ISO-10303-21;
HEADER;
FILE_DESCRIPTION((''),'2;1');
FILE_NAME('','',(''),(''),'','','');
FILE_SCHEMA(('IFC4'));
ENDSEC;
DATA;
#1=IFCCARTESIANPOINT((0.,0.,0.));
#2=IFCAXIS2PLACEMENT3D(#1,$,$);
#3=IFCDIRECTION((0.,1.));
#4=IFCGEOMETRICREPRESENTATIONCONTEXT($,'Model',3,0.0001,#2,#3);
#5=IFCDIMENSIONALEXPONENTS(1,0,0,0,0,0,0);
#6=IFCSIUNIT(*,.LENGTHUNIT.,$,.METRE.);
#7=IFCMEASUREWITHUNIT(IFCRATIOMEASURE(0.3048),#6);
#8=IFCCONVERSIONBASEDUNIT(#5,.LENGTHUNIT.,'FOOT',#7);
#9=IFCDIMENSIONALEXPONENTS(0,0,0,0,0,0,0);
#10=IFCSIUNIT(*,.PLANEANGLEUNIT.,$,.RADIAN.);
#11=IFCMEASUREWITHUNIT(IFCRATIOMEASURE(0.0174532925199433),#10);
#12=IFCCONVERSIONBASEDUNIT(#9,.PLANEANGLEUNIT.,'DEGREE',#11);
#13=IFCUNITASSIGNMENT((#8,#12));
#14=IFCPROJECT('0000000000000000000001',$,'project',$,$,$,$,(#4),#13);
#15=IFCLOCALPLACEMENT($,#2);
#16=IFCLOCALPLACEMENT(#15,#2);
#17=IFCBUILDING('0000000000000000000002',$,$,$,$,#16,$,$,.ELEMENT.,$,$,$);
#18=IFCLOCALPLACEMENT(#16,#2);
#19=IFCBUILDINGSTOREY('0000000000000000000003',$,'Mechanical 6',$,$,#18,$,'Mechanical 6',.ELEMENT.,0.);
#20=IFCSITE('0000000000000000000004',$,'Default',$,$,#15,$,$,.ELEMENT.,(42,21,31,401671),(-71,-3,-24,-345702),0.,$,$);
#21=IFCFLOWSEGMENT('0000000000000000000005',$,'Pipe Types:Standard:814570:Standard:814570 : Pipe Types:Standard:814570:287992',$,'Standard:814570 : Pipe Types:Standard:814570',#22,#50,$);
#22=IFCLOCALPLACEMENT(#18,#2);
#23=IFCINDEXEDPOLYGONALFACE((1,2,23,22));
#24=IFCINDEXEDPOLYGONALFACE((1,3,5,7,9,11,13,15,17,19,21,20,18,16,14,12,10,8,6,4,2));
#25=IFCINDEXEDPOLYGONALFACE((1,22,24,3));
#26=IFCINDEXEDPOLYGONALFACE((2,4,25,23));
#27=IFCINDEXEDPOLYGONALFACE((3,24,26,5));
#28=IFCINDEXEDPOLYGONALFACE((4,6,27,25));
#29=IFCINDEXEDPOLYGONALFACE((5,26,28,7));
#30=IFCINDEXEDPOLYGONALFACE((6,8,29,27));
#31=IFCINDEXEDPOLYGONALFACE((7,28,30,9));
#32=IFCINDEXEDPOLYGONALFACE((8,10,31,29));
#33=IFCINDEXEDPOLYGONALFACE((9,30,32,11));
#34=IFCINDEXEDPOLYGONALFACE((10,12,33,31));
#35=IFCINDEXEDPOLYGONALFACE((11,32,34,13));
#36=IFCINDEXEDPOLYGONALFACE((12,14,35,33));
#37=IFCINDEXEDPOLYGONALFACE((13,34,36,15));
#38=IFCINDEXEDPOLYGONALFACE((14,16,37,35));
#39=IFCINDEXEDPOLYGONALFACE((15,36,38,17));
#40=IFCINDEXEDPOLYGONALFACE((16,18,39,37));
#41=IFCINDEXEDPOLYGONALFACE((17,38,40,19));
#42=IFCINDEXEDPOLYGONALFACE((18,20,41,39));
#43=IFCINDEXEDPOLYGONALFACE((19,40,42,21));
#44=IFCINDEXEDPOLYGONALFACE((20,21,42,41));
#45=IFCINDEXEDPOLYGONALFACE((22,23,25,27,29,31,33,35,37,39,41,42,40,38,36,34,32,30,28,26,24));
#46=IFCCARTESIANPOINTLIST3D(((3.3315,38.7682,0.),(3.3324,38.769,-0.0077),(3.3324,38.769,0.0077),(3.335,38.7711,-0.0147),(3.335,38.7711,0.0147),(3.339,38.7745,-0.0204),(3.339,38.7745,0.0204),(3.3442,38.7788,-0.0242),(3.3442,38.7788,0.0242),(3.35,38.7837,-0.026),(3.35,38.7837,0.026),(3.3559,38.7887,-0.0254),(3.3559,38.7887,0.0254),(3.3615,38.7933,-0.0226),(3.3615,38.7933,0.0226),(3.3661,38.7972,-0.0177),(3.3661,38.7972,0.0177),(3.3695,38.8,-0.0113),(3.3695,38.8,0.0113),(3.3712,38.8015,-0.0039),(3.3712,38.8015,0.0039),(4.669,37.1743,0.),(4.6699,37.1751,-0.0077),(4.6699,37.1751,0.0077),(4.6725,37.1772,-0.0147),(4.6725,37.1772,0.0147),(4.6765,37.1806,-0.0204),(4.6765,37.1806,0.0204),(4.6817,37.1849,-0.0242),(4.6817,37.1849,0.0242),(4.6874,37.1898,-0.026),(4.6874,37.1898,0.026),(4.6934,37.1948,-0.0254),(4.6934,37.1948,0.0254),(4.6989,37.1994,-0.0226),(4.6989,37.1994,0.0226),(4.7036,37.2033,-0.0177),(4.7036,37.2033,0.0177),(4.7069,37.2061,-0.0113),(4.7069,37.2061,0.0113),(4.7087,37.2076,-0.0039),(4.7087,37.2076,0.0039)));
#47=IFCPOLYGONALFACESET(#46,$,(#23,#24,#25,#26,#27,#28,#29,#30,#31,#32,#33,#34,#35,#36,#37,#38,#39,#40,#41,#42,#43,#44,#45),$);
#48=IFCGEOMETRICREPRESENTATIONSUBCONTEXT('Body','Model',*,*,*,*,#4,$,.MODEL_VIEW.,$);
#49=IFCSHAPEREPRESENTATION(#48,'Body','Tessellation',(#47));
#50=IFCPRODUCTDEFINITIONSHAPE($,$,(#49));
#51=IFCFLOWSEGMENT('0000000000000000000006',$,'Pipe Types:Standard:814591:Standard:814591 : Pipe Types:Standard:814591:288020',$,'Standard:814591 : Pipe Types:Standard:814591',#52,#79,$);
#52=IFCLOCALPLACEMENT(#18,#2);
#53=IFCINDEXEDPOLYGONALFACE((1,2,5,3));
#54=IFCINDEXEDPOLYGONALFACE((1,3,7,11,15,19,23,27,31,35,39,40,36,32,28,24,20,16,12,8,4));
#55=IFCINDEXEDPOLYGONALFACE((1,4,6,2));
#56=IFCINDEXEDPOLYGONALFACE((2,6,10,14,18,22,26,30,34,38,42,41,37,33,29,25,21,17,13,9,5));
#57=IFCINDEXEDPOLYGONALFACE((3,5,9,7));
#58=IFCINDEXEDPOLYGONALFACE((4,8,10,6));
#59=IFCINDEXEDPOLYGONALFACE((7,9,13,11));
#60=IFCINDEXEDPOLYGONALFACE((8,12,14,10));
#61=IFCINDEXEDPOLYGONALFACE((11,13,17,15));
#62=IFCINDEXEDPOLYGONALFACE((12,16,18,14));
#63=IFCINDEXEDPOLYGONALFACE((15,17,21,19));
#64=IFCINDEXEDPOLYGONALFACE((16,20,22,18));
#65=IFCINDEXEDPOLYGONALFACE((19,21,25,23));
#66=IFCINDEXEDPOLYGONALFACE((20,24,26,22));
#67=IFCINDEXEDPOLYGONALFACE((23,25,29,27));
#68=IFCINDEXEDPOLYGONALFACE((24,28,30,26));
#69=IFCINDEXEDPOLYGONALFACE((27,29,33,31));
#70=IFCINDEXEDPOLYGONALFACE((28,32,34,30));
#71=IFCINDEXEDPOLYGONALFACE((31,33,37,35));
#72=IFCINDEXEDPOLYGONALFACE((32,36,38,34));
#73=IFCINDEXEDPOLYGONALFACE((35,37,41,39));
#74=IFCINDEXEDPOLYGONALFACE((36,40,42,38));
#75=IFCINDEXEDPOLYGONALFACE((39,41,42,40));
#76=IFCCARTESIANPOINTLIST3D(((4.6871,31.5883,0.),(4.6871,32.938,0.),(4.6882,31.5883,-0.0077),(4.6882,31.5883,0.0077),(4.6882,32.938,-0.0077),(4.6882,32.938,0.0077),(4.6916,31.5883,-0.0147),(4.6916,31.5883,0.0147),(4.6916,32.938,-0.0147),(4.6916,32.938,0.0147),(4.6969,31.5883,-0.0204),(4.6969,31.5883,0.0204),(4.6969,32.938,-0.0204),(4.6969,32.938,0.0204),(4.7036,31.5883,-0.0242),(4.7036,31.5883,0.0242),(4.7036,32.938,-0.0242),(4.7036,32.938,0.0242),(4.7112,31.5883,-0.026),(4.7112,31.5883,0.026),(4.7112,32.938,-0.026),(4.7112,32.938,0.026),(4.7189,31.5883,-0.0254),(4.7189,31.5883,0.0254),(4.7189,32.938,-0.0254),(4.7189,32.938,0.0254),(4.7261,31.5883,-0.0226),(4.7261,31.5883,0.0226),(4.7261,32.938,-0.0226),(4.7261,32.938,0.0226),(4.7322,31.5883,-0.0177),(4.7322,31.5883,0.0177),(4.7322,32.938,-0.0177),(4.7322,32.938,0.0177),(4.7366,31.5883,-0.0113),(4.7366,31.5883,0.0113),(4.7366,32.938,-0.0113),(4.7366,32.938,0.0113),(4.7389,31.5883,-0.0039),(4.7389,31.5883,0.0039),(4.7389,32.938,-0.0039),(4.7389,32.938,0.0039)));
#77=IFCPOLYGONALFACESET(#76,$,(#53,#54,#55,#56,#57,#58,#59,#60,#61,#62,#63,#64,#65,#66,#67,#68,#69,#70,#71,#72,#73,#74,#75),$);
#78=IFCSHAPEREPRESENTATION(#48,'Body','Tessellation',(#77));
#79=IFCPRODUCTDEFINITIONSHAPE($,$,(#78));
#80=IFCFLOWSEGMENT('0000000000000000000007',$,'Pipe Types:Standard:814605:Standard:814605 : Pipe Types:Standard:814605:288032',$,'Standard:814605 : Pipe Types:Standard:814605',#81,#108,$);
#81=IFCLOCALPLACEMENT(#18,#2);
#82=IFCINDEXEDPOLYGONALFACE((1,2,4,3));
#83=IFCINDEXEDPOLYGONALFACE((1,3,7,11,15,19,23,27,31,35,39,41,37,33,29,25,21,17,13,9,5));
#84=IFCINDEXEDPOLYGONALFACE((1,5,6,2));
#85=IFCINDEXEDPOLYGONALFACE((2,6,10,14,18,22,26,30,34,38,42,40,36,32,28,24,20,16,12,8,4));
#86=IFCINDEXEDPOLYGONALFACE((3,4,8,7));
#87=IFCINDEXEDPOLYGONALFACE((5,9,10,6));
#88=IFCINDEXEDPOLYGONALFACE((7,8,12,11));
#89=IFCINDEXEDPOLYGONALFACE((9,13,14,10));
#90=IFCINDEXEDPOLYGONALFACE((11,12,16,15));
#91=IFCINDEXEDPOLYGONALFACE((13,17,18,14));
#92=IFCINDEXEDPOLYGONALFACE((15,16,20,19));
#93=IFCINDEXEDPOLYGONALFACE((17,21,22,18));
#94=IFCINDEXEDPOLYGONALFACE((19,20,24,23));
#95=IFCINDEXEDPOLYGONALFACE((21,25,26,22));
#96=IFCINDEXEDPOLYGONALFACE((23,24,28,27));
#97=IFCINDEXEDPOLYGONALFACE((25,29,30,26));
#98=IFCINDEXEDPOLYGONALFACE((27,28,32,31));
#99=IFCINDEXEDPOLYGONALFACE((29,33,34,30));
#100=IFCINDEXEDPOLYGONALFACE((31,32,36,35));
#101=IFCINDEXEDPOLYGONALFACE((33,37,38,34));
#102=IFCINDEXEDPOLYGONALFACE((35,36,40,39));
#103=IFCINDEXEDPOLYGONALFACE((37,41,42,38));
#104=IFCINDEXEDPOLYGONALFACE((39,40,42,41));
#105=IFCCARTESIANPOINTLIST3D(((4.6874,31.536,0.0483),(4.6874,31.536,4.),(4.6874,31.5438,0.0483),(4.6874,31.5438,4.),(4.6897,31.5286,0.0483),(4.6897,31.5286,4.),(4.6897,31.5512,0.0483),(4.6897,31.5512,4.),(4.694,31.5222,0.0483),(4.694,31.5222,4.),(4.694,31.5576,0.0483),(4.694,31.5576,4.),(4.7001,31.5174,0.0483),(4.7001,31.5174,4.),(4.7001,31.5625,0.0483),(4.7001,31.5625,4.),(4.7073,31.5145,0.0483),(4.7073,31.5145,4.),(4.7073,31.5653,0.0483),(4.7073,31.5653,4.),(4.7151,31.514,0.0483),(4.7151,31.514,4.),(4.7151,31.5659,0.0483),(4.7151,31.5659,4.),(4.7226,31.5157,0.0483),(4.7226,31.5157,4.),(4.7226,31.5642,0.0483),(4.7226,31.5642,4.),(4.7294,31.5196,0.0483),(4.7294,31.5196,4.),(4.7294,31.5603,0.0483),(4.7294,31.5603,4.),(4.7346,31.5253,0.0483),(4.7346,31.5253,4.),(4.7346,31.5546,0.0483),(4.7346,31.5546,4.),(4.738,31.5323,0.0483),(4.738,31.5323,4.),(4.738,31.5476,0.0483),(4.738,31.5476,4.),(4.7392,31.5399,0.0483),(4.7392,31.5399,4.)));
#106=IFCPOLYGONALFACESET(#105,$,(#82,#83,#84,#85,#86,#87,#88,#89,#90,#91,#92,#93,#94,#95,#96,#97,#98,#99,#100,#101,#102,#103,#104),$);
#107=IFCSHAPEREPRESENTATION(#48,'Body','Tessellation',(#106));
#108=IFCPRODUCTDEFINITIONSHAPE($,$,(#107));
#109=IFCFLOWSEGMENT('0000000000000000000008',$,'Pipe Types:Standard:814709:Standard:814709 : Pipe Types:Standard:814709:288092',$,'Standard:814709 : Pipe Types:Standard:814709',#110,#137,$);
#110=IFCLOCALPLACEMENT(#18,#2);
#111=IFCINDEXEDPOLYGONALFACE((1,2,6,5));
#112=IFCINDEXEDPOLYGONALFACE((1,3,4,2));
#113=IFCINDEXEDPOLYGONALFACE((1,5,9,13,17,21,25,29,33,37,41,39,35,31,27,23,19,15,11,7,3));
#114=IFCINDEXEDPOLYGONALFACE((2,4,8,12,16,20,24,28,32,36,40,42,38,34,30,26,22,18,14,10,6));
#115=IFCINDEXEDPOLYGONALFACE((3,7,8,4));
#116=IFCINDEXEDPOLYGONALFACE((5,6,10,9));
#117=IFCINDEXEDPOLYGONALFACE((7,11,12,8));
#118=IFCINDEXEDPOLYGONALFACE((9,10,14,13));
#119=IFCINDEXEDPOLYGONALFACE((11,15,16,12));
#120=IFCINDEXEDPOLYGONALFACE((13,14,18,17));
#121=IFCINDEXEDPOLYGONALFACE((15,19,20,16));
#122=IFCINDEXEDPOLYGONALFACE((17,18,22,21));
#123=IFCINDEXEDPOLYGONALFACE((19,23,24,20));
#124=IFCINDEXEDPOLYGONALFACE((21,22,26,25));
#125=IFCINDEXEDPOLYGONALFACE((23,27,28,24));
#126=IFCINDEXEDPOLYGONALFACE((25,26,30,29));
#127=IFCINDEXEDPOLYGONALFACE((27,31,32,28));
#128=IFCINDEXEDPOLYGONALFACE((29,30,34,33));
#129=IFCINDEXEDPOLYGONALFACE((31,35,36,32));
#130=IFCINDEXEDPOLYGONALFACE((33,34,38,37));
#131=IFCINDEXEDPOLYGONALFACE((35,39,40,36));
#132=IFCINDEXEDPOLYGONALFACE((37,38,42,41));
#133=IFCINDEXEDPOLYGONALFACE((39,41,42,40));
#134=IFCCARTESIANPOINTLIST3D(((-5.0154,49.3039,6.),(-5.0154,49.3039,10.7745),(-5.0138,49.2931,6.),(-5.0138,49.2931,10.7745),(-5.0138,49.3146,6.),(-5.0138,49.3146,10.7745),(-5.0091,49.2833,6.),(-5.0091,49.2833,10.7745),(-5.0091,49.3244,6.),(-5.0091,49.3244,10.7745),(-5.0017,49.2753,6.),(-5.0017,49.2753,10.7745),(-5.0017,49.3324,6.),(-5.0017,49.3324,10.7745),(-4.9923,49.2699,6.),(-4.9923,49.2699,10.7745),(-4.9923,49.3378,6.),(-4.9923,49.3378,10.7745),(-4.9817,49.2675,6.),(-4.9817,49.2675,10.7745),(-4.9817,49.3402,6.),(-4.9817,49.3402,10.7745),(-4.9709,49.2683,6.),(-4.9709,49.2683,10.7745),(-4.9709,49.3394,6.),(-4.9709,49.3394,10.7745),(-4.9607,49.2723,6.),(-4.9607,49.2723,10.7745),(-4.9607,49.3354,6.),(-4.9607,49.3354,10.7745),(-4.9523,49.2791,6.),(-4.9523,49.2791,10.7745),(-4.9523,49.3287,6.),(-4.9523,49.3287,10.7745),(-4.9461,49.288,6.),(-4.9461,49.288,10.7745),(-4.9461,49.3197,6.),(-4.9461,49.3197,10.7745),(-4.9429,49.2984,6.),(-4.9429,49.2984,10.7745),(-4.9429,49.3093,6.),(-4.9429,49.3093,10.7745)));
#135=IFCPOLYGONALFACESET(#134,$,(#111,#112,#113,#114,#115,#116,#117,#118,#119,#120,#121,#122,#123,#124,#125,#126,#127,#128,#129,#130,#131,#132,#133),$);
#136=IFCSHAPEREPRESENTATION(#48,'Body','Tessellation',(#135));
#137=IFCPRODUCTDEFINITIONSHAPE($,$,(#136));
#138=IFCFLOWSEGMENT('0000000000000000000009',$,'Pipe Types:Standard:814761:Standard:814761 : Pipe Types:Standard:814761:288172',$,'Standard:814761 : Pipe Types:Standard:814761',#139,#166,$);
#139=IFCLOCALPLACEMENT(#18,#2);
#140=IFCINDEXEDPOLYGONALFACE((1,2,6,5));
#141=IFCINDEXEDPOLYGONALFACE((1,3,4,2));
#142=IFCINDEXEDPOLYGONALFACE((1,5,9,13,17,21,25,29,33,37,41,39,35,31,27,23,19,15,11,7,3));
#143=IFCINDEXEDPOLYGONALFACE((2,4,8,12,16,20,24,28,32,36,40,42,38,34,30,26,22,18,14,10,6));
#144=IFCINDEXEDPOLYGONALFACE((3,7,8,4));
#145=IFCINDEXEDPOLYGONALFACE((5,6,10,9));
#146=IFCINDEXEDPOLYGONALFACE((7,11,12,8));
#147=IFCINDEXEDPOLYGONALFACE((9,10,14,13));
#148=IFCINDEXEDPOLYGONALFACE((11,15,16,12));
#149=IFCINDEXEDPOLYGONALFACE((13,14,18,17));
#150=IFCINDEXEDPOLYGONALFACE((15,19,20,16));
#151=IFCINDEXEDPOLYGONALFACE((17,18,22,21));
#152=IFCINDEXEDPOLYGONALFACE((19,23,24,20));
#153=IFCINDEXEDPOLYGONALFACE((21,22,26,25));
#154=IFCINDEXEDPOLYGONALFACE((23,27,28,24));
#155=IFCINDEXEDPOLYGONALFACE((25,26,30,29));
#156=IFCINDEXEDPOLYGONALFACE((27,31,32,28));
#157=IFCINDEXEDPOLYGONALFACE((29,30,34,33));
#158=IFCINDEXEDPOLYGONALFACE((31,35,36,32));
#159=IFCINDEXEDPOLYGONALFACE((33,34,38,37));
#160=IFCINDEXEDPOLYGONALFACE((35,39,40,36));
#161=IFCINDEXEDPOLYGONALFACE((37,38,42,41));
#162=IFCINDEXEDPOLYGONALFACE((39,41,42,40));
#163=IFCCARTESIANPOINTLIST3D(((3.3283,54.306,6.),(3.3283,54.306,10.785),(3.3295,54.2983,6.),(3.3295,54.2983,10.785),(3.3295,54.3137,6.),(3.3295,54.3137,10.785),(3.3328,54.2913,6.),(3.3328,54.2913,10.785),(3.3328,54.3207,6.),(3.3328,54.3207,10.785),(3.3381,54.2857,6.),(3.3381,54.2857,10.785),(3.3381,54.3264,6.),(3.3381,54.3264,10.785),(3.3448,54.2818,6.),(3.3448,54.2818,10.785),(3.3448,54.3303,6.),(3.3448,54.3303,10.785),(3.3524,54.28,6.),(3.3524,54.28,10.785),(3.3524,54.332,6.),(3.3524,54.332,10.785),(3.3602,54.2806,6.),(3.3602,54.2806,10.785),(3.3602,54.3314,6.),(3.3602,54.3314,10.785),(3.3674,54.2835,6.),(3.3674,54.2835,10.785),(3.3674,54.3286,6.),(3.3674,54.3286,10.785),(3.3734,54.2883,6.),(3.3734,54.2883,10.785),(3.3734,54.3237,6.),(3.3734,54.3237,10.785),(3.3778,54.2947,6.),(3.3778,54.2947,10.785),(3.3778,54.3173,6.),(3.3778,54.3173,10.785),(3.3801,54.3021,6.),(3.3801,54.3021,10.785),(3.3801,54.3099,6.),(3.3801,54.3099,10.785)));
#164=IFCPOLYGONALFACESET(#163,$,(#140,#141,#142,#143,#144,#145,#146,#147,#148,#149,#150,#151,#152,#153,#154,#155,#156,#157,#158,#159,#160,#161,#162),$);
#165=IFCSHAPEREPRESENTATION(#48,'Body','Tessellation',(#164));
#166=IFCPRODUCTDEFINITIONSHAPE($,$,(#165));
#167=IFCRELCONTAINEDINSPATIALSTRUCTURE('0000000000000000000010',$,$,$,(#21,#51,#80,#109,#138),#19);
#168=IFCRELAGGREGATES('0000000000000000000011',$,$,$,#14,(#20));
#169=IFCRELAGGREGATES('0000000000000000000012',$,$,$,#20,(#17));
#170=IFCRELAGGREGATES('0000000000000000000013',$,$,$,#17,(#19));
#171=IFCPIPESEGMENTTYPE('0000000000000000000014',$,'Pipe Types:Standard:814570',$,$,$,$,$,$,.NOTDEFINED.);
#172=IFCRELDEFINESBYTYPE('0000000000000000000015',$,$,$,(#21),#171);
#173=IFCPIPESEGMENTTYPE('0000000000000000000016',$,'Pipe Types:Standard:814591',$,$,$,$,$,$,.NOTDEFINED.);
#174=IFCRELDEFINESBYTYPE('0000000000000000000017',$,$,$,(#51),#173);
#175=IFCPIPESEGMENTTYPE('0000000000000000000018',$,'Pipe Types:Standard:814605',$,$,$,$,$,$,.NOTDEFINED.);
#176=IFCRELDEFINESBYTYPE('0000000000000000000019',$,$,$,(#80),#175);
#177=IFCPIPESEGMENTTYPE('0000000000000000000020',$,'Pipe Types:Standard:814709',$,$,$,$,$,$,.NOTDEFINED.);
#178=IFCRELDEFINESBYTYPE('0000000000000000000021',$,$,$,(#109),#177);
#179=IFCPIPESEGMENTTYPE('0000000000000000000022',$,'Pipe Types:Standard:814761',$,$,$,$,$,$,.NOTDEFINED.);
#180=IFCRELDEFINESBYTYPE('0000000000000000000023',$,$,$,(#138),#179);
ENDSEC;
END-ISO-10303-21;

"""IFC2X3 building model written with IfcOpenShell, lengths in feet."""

from ifc_helpers import new_model, entity, si_unit, converted_unit, direction, frame, frame_2d, origin, origin_2d_with_axis, place, context, subcontext, project, spatial, circle, extrude, source, transform, mapped, type_object, type_shapes, element, save


model = new_model("IFC2X3")

# Units and contexts
model_context = context("Model", 3, precision=0.0001, world=origin(), true_north=direction((0.0, 1.0)))
body_context = subcontext(model_context, "Body", "Model", "MODEL_VIEW")
ifc_project = project(units=[converted_unit("LENGTHUNIT", "FOOT", entity("IfcRatioMeasure", 0.3048), si_unit("LENGTHUNIT", "METRE"), dimensions=[1, 0, 0, 0, 0, 0, 0]), converted_unit("PLANEANGLEUNIT", "DEGREE", entity("IfcRatioMeasure", 0.0174532925199433), si_unit("PLANEANGLEUNIT", "RADIAN"), dimensions=[0, 0, 0, 0, 0, 0, 0])], contexts=[model_context])

# Site, building, storey
site_placement = place(None, origin())
site = spatial("IfcSite", under=ifc_project, at=site_placement, Name="Default", CompositionType="ELEMENT", RefLatitude=(42, 21, 31, 401671), RefLongitude=(-71, -3, -24, -345702), RefElevation=0.0)
building_placement = place(site_placement, origin())
building = spatial("IfcBuilding", under=site, at=building_placement, CompositionType="ELEMENT")
storey_placement = place(building_placement, origin())
storey = spatial("IfcBuildingStorey", under=building, at=storey_placement, Name="Mechanical 6", LongName="Mechanical 6", CompositionType="ELEMENT", Elevation=0.0)

# Flow segments
pipe_segment_type_1 = type_object("IfcPipeSegmentType", Name="Pipe Types:Standard:814570", PredefinedType="NOTDEFINED")
shared_shape_1 = source(origin(), body_context, "Body", "SweptSolid", [
    extrude(circle(Radius=0.026, at=frame_2d((0.0, 0.0), x_axis=(1.0, 0.0))), frame((3.3515, 38.785, 0.0), z_axis=(0.642788, -0.766044, 0.0), x_axis=(-0.766044, -0.642788, 0.0)), (0.0, 0.0, 1.0), 2.0807),
])
type_shapes(pipe_segment_type_1, [shared_shape_1])
flow_segment_1_placement = place(building_placement, origin())
element("IfcFlowSegment", 1, at=flow_segment_1_placement, inside=storey, type_object=pipe_segment_type_1, Name="Pipe Types:Standard:814570:Standard:814570 : Pipe Types:Standard:814570:287992", ObjectType="Standard:814570 : Pipe Types:Standard:814570", context=body_context, shape_type="MappedRepresentation", body=[
    mapped(shared_shape_1, transform((0.0, 0.0, 0.0), scale=1.0)),
])
pipe_segment_type_2 = type_object("IfcPipeSegmentType", Name="Pipe Types:Standard:814591", PredefinedType="NOTDEFINED")
shared_shape_2 = source(origin(), body_context, "Body", "SweptSolid", [
    extrude(circle(Radius=0.026, at=frame_2d((0.0, 0.0), x_axis=(1.0, 0.0))), frame((4.7131, 31.5883, 0.0), z_axis=(0.0, 1.0, 0.0), x_axis=(-1.0, 0.0, 0.0)), (0.0, 0.0, 1.0), 1.3498),
])
type_shapes(pipe_segment_type_2, [shared_shape_2])
flow_segment_2_placement = place(building_placement, origin())
element("IfcFlowSegment", 2, at=flow_segment_2_placement, inside=storey, type_object=pipe_segment_type_2, Name="Pipe Types:Standard:814591:Standard:814591 : Pipe Types:Standard:814591:288020", ObjectType="Standard:814591 : Pipe Types:Standard:814591", context=body_context, shape_type="MappedRepresentation", body=[
    mapped(shared_shape_2, transform((0.0, 0.0, 0.0), scale=1.0)),
])
pipe_segment_type_3 = type_object("IfcPipeSegmentType", Name="Pipe Types:Standard:814605", PredefinedType="NOTDEFINED")
shared_shape_3 = source(origin(), body_context, "Body", "SweptSolid", [
    extrude(circle(Radius=0.026, at=origin_2d_with_axis()), frame((4.7131, 31.5399, 0.0483)), (0.0, 0.0, 1.0), 3.9517),
])
type_shapes(pipe_segment_type_3, [shared_shape_3])
flow_segment_3_placement = place(building_placement, origin())
element("IfcFlowSegment", 3, at=flow_segment_3_placement, inside=storey, type_object=pipe_segment_type_3, Name="Pipe Types:Standard:814605:Standard:814605 : Pipe Types:Standard:814605:288032", ObjectType="Standard:814605 : Pipe Types:Standard:814605", context=body_context, shape_type="MappedRepresentation", body=[
    mapped(shared_shape_3, transform((0.0, 0.0, 0.0), scale=1.0)),
])
pipe_segment_type_4 = type_object("IfcPipeSegmentType", Name="Pipe Types:Standard:814709", PredefinedType="NOTDEFINED")
shared_shape_4 = source(origin(), body_context, "Body", "SweptSolid", [
    extrude(circle(Radius=0.0365, at=origin_2d_with_axis()), frame((-4.979, 49.3039, 6.0), z_axis=(0.0, 0.0, 1.0), x_axis=(-1.0, 0.0, 0.0)), (0.0, 0.0, 1.0), 4.7745),
])
type_shapes(pipe_segment_type_4, [shared_shape_4])
flow_segment_4_placement = place(building_placement, origin())
element("IfcFlowSegment", 4, at=flow_segment_4_placement, inside=storey, type_object=pipe_segment_type_4, Name="Pipe Types:Standard:814709:Standard:814709 : Pipe Types:Standard:814709:288092", ObjectType="Standard:814709 : Pipe Types:Standard:814709", context=body_context, shape_type="MappedRepresentation", body=[
    mapped(shared_shape_4, transform((0.0, 0.0, 0.0), scale=1.0)),
])
pipe_segment_type_5 = type_object("IfcPipeSegmentType", Name="Pipe Types:Standard:814761", PredefinedType="NOTDEFINED")
shared_shape_5 = source(origin(), body_context, "Body", "SweptSolid", [
    extrude(circle(Radius=0.026, at=origin_2d_with_axis()), frame((3.3544, 54.306, 6.0), z_axis=(0.0, 0.0, 1.0), x_axis=(-1.0, 0.0, 0.0)), (0.0, 0.0, 1.0), 4.785),
])
type_shapes(pipe_segment_type_5, [shared_shape_5])
flow_segment_5_placement = place(building_placement, origin())
element("IfcFlowSegment", 5, at=flow_segment_5_placement, inside=storey, type_object=pipe_segment_type_5, Name="Pipe Types:Standard:814761:Standard:814761 : Pipe Types:Standard:814761:288172", ObjectType="Standard:814761 : Pipe Types:Standard:814761", context=body_context, shape_type="MappedRepresentation", body=[
    mapped(shared_shape_5, transform((0.0, 0.0, 0.0), scale=1.0)),
])

save(model, "model.ifc")
